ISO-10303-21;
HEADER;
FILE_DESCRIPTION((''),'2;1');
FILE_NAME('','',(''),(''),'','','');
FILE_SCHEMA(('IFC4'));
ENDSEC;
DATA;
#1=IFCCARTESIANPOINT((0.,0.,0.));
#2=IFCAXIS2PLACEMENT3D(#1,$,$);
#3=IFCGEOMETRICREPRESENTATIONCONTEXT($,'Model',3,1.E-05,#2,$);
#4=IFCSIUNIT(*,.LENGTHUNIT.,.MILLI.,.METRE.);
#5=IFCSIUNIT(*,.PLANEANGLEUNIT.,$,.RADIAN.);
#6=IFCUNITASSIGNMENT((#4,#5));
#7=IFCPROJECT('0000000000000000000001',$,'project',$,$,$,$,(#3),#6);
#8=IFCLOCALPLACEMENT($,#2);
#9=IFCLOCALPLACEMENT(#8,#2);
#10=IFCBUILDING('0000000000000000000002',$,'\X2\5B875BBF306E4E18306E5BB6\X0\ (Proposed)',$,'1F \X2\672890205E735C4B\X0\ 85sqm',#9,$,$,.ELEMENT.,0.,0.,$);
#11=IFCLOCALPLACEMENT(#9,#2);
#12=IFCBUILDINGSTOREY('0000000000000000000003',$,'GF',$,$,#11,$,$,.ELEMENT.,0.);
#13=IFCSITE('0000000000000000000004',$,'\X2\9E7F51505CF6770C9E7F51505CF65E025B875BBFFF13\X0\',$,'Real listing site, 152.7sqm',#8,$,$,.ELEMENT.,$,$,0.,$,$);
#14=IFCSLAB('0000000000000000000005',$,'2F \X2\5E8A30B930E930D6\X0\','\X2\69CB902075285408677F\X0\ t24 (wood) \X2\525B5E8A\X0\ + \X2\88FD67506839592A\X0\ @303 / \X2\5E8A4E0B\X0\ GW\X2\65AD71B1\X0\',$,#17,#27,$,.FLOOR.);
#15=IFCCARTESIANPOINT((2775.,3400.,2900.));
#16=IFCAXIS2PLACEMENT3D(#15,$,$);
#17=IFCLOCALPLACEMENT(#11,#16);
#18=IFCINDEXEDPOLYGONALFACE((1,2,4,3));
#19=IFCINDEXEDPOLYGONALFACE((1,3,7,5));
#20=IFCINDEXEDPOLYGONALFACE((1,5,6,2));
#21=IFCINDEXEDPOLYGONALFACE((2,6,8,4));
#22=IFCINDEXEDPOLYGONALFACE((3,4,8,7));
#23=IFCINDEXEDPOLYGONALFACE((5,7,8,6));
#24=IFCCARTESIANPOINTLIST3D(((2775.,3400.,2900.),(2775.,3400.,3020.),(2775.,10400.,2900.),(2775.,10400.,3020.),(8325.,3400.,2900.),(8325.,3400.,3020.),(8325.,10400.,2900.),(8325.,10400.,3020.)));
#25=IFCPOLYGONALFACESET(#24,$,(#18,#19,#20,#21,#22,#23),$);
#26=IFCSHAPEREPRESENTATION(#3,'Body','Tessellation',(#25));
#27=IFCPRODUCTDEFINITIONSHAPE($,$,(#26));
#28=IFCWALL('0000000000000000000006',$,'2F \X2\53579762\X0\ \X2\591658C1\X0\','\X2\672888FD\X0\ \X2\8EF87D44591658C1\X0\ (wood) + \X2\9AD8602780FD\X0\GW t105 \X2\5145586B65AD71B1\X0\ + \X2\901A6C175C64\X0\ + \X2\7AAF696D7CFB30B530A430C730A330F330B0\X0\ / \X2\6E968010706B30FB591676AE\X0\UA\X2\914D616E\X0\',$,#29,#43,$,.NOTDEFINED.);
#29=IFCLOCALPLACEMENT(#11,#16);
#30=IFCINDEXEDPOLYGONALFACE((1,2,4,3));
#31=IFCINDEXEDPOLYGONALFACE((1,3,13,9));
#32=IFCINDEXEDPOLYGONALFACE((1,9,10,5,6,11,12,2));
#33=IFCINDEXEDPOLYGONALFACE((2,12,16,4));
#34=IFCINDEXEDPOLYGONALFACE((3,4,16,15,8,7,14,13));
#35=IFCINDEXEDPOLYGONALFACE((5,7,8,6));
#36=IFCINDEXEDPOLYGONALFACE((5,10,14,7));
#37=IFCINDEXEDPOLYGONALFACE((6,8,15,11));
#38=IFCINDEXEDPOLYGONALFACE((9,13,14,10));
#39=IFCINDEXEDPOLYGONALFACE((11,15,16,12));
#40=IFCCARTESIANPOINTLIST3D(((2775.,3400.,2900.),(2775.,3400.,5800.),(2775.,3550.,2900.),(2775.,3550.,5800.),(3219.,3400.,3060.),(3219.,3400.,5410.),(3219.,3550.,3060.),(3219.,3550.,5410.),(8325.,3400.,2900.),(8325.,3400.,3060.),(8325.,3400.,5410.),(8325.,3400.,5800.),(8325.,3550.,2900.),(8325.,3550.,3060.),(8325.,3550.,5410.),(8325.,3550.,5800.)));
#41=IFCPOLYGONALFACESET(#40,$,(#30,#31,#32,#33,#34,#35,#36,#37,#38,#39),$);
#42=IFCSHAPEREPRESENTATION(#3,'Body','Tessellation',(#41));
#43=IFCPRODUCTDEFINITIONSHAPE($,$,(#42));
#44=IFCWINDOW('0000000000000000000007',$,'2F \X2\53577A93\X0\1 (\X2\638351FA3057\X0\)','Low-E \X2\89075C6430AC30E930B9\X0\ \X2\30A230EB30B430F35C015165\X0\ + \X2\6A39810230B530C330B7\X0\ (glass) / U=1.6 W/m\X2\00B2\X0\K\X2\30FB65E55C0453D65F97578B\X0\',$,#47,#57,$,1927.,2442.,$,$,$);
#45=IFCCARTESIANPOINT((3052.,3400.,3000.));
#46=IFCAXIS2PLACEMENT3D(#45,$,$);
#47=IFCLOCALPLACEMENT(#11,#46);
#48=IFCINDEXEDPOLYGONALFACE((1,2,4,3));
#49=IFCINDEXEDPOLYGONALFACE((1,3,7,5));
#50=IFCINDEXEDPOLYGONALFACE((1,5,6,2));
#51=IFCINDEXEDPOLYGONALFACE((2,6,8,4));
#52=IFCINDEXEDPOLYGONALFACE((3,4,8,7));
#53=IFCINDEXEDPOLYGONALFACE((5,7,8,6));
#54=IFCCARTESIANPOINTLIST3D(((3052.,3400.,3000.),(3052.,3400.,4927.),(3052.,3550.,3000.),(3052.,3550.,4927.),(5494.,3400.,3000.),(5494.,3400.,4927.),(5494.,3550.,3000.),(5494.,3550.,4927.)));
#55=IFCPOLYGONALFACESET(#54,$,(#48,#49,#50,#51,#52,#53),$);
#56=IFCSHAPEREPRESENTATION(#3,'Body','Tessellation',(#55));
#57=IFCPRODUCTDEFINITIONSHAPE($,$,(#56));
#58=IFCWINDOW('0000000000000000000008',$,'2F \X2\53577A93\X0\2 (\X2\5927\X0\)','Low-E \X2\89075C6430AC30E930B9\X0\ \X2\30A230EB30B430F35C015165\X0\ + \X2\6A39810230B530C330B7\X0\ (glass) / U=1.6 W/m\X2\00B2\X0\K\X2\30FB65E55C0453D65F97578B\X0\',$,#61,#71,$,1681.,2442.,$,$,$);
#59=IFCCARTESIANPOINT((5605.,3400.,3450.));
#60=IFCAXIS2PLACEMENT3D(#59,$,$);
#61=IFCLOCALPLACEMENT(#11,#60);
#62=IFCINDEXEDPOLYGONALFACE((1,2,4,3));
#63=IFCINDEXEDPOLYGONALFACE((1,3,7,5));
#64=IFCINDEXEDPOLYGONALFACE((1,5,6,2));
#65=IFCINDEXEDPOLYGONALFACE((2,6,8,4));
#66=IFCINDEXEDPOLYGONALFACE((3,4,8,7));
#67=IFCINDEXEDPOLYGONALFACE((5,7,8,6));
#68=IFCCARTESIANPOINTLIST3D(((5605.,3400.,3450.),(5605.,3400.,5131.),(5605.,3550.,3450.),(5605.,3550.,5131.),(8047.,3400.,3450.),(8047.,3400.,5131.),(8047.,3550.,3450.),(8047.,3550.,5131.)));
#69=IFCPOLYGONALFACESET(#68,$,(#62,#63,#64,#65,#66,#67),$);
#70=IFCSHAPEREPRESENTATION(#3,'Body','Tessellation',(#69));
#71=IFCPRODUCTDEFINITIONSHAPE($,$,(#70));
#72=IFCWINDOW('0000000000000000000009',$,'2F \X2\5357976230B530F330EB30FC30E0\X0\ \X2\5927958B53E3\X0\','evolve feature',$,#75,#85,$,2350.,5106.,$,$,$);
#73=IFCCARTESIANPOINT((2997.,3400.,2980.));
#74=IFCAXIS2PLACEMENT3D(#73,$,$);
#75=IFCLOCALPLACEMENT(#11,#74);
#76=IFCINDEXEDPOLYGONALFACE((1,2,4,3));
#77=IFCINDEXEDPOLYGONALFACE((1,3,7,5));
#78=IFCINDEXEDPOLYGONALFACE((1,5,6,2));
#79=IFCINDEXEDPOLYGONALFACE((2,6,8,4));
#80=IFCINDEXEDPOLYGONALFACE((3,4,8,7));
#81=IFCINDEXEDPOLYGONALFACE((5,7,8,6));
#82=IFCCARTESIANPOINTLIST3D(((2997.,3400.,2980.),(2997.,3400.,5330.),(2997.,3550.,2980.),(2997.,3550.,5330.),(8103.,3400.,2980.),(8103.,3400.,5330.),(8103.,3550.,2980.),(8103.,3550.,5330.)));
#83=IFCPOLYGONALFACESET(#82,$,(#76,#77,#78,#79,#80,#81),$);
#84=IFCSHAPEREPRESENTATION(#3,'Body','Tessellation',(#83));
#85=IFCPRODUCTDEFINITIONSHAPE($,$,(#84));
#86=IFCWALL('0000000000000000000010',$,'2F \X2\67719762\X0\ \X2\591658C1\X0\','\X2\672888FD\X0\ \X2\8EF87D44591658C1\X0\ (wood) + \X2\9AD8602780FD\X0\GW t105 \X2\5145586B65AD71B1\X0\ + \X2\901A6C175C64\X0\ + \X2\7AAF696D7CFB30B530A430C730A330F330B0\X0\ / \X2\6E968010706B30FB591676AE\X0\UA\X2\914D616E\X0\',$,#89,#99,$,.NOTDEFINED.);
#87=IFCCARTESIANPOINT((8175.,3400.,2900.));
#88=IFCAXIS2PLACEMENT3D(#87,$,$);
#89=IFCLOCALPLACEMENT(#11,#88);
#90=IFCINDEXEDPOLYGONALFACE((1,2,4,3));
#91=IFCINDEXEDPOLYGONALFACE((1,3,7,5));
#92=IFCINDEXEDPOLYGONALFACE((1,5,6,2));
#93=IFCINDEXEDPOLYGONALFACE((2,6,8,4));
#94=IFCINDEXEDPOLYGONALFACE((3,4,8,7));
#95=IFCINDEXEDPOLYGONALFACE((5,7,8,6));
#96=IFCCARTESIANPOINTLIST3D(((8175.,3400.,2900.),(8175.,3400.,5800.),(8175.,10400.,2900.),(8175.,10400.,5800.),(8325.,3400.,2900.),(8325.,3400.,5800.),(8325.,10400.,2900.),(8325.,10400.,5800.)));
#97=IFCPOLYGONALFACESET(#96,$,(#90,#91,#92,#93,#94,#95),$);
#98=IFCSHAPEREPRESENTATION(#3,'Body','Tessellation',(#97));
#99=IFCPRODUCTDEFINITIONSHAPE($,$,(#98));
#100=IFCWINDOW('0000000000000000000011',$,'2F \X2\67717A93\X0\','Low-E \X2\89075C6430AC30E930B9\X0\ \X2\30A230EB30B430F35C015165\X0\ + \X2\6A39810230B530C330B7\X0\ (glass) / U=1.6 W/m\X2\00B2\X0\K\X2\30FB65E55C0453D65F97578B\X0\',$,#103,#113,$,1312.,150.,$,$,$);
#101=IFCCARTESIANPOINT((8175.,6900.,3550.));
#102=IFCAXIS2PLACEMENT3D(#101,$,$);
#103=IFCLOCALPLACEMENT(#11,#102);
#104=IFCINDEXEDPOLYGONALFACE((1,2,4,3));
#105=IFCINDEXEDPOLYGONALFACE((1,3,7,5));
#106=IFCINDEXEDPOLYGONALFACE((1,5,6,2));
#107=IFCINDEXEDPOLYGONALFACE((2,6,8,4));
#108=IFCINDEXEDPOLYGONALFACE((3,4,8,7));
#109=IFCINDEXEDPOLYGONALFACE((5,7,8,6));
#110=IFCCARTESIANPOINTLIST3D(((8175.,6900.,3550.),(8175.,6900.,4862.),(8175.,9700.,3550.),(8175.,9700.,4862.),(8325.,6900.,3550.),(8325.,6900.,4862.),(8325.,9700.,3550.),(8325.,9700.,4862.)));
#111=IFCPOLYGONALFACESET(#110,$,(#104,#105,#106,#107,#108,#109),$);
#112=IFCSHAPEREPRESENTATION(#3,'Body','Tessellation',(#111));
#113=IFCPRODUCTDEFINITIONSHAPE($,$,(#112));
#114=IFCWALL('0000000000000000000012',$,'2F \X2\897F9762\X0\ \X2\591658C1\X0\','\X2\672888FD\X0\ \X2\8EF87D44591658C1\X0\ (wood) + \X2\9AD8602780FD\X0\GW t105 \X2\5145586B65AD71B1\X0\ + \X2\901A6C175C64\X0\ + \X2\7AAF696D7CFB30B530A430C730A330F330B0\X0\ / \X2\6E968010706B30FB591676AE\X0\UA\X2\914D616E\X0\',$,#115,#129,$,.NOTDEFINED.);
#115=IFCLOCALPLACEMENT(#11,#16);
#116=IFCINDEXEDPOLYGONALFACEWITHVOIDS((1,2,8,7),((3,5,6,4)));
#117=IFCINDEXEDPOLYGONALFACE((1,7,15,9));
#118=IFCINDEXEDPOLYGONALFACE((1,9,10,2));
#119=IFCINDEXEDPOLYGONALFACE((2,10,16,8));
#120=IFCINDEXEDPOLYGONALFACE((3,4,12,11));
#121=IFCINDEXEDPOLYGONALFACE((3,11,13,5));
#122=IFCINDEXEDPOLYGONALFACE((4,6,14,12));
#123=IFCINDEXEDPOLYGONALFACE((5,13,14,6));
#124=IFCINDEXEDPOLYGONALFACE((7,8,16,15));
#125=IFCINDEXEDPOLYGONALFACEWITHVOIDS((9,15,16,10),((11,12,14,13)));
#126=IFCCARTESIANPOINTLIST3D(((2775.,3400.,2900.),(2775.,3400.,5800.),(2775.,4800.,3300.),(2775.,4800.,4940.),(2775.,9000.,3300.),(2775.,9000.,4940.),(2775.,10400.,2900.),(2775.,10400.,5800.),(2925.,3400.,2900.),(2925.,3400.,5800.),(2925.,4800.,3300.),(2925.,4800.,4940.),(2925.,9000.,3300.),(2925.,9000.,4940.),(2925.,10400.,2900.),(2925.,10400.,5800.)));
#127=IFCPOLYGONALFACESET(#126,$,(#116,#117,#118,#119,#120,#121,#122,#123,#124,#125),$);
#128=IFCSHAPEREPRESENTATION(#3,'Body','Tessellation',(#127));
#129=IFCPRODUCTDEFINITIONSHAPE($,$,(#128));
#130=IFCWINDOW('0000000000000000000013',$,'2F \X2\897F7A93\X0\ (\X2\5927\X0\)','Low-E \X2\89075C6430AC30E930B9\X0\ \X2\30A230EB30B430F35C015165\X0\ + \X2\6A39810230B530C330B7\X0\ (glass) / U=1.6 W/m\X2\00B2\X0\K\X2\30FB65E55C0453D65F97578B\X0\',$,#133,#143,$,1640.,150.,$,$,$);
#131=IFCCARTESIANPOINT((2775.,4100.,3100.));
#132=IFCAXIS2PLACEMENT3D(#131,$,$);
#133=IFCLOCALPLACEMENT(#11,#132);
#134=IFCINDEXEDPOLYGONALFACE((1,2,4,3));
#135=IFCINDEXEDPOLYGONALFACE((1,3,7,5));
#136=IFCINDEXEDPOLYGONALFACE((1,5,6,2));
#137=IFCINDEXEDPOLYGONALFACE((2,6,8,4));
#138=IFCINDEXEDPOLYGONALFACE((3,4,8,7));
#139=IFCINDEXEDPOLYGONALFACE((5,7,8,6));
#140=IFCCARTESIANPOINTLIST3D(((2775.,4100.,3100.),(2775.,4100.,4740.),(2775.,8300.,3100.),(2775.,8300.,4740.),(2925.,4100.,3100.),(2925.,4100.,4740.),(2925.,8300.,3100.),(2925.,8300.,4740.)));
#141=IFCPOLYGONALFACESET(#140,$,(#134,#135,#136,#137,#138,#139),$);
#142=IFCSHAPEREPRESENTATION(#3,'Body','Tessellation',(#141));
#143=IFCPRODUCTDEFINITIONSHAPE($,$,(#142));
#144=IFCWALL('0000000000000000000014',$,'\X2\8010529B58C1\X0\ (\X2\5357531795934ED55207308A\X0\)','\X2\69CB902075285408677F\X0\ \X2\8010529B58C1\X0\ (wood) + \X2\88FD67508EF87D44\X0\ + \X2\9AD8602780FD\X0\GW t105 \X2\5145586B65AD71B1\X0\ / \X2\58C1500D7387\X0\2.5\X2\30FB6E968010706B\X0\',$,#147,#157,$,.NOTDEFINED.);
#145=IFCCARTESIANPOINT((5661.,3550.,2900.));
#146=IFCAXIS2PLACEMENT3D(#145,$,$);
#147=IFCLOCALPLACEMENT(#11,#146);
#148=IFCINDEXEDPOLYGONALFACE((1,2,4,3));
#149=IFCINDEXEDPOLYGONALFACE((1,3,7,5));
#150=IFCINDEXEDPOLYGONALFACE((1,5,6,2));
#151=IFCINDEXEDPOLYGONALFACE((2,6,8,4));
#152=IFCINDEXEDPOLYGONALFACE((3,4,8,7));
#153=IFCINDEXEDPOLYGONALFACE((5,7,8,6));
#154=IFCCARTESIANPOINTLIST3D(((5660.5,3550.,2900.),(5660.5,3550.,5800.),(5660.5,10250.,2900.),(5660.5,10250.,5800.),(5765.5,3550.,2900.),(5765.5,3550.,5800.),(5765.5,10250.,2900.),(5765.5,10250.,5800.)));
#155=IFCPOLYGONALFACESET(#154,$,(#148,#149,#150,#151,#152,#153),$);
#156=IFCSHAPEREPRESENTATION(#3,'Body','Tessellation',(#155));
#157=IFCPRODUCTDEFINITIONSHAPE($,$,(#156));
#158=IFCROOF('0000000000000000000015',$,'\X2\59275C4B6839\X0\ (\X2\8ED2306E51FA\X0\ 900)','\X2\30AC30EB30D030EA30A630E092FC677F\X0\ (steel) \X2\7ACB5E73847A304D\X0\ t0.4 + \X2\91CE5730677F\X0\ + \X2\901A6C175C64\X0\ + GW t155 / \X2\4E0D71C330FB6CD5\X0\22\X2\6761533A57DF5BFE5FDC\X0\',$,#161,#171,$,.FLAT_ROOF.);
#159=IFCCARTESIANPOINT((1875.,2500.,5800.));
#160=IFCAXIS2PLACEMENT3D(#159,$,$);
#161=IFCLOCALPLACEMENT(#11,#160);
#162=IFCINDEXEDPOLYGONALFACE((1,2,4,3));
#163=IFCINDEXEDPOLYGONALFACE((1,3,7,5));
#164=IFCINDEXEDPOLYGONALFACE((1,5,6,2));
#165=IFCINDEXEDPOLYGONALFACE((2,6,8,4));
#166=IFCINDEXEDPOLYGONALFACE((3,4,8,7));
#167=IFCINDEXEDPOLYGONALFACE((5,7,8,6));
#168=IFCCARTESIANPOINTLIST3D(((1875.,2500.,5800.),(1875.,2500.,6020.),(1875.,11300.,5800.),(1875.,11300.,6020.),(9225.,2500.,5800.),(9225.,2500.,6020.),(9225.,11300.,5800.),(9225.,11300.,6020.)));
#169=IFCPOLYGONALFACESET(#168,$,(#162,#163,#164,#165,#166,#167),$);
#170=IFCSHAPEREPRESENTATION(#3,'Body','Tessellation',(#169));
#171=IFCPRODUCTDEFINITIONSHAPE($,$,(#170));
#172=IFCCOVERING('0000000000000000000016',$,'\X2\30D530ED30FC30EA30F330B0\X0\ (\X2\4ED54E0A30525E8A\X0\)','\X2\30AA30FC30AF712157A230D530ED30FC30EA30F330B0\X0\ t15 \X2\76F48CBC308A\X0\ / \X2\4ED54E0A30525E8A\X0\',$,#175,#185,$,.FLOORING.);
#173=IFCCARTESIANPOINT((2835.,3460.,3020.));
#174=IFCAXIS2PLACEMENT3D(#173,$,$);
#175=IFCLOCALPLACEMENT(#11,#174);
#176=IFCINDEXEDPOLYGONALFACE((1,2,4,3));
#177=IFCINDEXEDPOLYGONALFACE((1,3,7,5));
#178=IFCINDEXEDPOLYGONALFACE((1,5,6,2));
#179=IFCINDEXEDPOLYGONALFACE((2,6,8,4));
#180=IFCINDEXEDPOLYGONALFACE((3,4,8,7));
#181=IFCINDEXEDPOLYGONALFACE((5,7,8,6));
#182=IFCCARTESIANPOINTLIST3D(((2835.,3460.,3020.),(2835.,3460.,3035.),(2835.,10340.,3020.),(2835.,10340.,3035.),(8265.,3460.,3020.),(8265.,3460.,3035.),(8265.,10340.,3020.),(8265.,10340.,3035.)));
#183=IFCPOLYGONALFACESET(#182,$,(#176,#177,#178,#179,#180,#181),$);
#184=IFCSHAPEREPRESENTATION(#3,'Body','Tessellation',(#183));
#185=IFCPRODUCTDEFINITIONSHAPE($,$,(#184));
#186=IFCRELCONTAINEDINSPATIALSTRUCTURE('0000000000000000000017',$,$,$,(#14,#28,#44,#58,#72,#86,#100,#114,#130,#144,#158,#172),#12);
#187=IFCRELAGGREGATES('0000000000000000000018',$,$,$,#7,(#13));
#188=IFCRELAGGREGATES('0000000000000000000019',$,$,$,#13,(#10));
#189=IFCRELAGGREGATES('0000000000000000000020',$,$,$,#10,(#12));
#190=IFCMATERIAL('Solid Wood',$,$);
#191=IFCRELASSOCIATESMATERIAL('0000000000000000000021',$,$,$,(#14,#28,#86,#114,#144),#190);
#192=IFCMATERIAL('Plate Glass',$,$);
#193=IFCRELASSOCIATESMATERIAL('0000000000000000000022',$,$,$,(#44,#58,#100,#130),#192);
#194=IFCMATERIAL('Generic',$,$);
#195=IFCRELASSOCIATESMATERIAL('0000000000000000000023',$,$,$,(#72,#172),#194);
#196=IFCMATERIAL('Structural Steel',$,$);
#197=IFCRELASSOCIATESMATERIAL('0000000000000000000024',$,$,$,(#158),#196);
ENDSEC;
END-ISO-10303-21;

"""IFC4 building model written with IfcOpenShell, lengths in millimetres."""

from ifc_helpers import new_model, si_unit, frame, frame_2d, origin, place, context, project, spatial, rectangle, extrude, material, element, fill, save


model = new_model("IFC4")

# Units and contexts
model_context = context("Model", 3, precision=1e-05, world=origin())
ifc_project = project(units=[si_unit("LENGTHUNIT", "METRE", prefix="MILLI"), si_unit("PLANEANGLEUNIT", "RADIAN")], contexts=[model_context])

# Site, building, storey
site_placement = place(None, origin())
site = spatial("IfcSite", under=ifc_project, at=site_placement, Name="鹿児島県鹿児島市宇宿３", ObjectType="Real listing site, 152.7sqm", CompositionType="ELEMENT", RefElevation=0.0)
building_placement = place(site_placement, origin())
building = spatial("IfcBuilding", under=site, at=building_placement, Name="宇宿の丘の家 (Proposed)", ObjectType="1F 木造平屋 85sqm", CompositionType="ELEMENT", ElevationOfRefHeight=0.0, ElevationOfTerrain=0.0)
storey_placement = place(building_placement, origin())
storey = spatial("IfcBuildingStorey", under=building, at=storey_placement, Name="GF", CompositionType="ELEMENT", Elevation=0.0)

# Slab
ifc_material_1 = material(Name="Solid Wood")
slab_placement = place(storey_placement, frame((2775.0, 3400.0, 2900.0)))
element("IfcSlab", 1, at=slab_placement, inside=storey, material=ifc_material_1, Name="2F 床スラブ", Description="構造用合板 t24 (wood) 剛床 + 製材根太 @303 / 床下 GW断熱", PredefinedType="FLOOR", context=model_context, shape_type="SweptSolid", body=[
    extrude(rectangle(XDim=5550.0, YDim=7000.0, at=frame_2d((2775.0, 3500.0))), frame((2775.0, 3400.0, 2900.0)), (0.0, 0.0, 1.0), 120.0),
])

# Wall, openings, windows
wall_1_placement = place(storey_placement, frame((2775.0, 3400.0, 2900.0)))
wall_1 = element("IfcWall", 2, at=wall_1_placement, inside=storey, material=ifc_material_1, Name="2F 南面 外壁", Description="木製 軸組外壁 (wood) + 高性能GW t105 充填断熱 + 通気層 + 窯業系サイディング / 準耐火・外皮UA配慮", PredefinedType="NOTDEFINED", context=model_context, shape_type="SweptSolid", body=[
    extrude(rectangle(XDim=5550.0, YDim=150.0, at=frame_2d((2775.0, 75.0))), frame((2775.0, 3400.0, 2900.0)), (0.0, 0.0, 1.0), 2900.0),
])
opening_1_placement = place(storey_placement, frame((3052.0, 3400.0, 3000.0)))
opening_1 = element("IfcOpeningElement", 3, at=opening_1_placement, cuts=wall_1, PredefinedType="NOTDEFINED", context=model_context, shape_type="SweptSolid", body=[
    extrude(rectangle(XDim=2442.0, YDim=150.0, at=frame_2d((1221.0, 75.0))), frame((3052.0, 3400.0, 3000.0)), (0.0, 0.0, 1.0), 1927.0),
])
opening_2_placement = place(storey_placement, frame((5605.0, 3400.0, 3450.0)))
opening_2 = element("IfcOpeningElement", 4, at=opening_2_placement, cuts=wall_1, PredefinedType="NOTDEFINED", context=model_context, shape_type="SweptSolid", body=[
    extrude(rectangle(XDim=2442.0, YDim=150.0, at=frame_2d((1221.0, 75.0))), frame((5605.0, 3400.0, 3450.0)), (0.0, 0.0, 1.0), 1681.0),
])
opening_3_placement = place(storey_placement, frame((2997.0, 3400.0, 2980.0)))
opening_3 = element("IfcOpeningElement", 5, at=opening_3_placement, cuts=wall_1, PredefinedType="NOTDEFINED", context=model_context, shape_type="SweptSolid", body=[
    extrude(rectangle(XDim=5106.0, YDim=150.0, at=frame_2d((2553.0, 75.0))), frame((2997.0, 3400.0, 2980.0)), (0.0, 0.0, 1.0), 2350.0),
])
ifc_material_2 = material(Name="Plate Glass")
window_1_placement = place(storey_placement, frame((3052.0, 3400.0, 3000.0)))
window_1 = element("IfcWindow", 6, at=window_1_placement, inside=storey, material=ifc_material_2, Name="2F 南窓1 (掃出し)", Description="Low-E 複層ガラス アルゴン封入 + 樹脂サッシ (glass) / U=1.6 W/m²K・日射取得型", OverallHeight=1927.0, OverallWidth=2442.0, context=model_context, shape_type="SweptSolid", body=[
    extrude(rectangle(XDim=2442.0, YDim=150.0, at=frame_2d((1221.0, 75.0))), frame((3052.0, 3400.0, 3000.0)), (0.0, 0.0, 1.0), 1927.0),
])
fill(opening_1, window_1)
window_2_placement = place(storey_placement, frame((5605.0, 3400.0, 3450.0)))
window_2 = element("IfcWindow", 7, at=window_2_placement, inside=storey, material=ifc_material_2, Name="2F 南窓2 (大)", Description="Low-E 複層ガラス アルゴン封入 + 樹脂サッシ (glass) / U=1.6 W/m²K・日射取得型", OverallHeight=1681.0, OverallWidth=2442.0, context=model_context, shape_type="SweptSolid", body=[
    extrude(rectangle(XDim=2442.0, YDim=150.0, at=frame_2d((1221.0, 75.0))), frame((5605.0, 3400.0, 3450.0)), (0.0, 0.0, 1.0), 1681.0),
])
fill(opening_2, window_2)
ifc_material_3 = material(Name="Generic")
window_3_placement = place(storey_placement, frame((2997.0, 3400.0, 2980.0)))
window_3 = element("IfcWindow", 8, at=window_3_placement, inside=storey, material=ifc_material_3, Name="2F 南面サンルーム 大開口", Description="evolve feature", OverallHeight=2350.0, OverallWidth=5106.0, context=model_context, shape_type="SweptSolid", body=[
    extrude(rectangle(XDim=5106.0, YDim=150.0, at=frame_2d((2553.0, 75.0))), frame((2997.0, 3400.0, 2980.0)), (0.0, 0.0, 1.0), 2350.0),
])
fill(opening_3, window_3)

# Walls, openings, windows
wall_2_placement = place(storey_placement, frame((8175.0, 3400.0, 2900.0)))
wall_2 = element("IfcWall", 9, at=wall_2_placement, inside=storey, material=ifc_material_1, Name="2F 東面 外壁", Description="木製 軸組外壁 (wood) + 高性能GW t105 充填断熱 + 通気層 + 窯業系サイディング / 準耐火・外皮UA配慮", PredefinedType="NOTDEFINED", context=model_context, shape_type="SweptSolid", body=[
    extrude(rectangle(XDim=150.0, YDim=7000.0, at=frame_2d((75.0, 3500.0))), frame((8175.0, 3400.0, 2900.0)), (0.0, 0.0, 1.0), 2900.0),
])
opening_4_placement = place(storey_placement, frame((8175.0, 6900.0, 3550.0)))
opening_4 = element("IfcOpeningElement", 10, at=opening_4_placement, cuts=wall_2, PredefinedType="NOTDEFINED", context=model_context, shape_type="SweptSolid", body=[
    extrude(rectangle(XDim=150.0, YDim=2800.0, at=frame_2d((75.0, 1400.0))), frame((8175.0, 6900.0, 3550.0)), (0.0, 0.0, 1.0), 1312.0),
])
window_4_placement = place(storey_placement, frame((8175.0, 6900.0, 3550.0)))
window_4 = element("IfcWindow", 11, at=window_4_placement, inside=storey, material=ifc_material_2, Name="2F 東窓", Description="Low-E 複層ガラス アルゴン封入 + 樹脂サッシ (glass) / U=1.6 W/m²K・日射取得型", OverallHeight=1312.0, OverallWidth=150.0, context=model_context, shape_type="SweptSolid", body=[
    extrude(rectangle(XDim=150.0, YDim=2800.0, at=frame_2d((75.0, 1400.0))), frame((8175.0, 6900.0, 3550.0)), (0.0, 0.0, 1.0), 1312.0),
])
fill(opening_4, window_4)
wall_3_placement = place(storey_placement, frame((2775.0, 3400.0, 2900.0)))
wall_3 = element("IfcWall", 12, at=wall_3_placement, inside=storey, material=ifc_material_1, Name="2F 西面 外壁", Description="木製 軸組外壁 (wood) + 高性能GW t105 充填断熱 + 通気層 + 窯業系サイディング / 準耐火・外皮UA配慮", PredefinedType="NOTDEFINED", context=model_context, shape_type="SweptSolid", body=[
    extrude(rectangle(XDim=150.0, YDim=7000.0, at=frame_2d((75.0, 3500.0))), frame((2775.0, 3400.0, 2900.0)), (0.0, 0.0, 1.0), 2900.0),
])
opening_5_placement = place(storey_placement, frame((2775.0, 4100.0, 3100.0)))
opening_5 = element("IfcOpeningElement", 13, at=opening_5_placement, cuts=wall_3, PredefinedType="NOTDEFINED", context=model_context, shape_type="SweptSolid", body=[
    extrude(rectangle(XDim=150.0, YDim=4200.0, at=frame_2d((75.0, 2100.0))), frame((2775.0, 4100.0, 3100.0)), (0.0, 0.0, 1.0), 1640.0),
])
window_5_placement = place(storey_placement, frame((2775.0, 4100.0, 3100.0)))
window_5 = element("IfcWindow", 14, at=window_5_placement, inside=storey, material=ifc_material_2, Name="2F 西窓 (大)", Description="Low-E 複層ガラス アルゴン封入 + 樹脂サッシ (glass) / U=1.6 W/m²K・日射取得型", OverallHeight=1640.0, OverallWidth=150.0, context=model_context, shape_type="SweptSolid", body=[
    extrude(rectangle(XDim=150.0, YDim=4200.0, at=frame_2d((75.0, 2100.0))), frame((2775.0, 4100.0, 3100.0)), (0.0, 0.0, 1.0), 1640.0),
])
fill(opening_5, window_5)

# Wall
wall_4_placement = place(storey_placement, frame((5661.0, 3550.0, 2900.0)))
element("IfcWall", 15, at=wall_4_placement, inside=storey, material=ifc_material_1, Name="耐力壁 (南北間仕切り)", Description="構造用合板 耐力壁 (wood) + 製材軸組 + 高性能GW t105 充填断熱 / 壁倍率2.5・準耐火", PredefinedType="NOTDEFINED", context=model_context, shape_type="SweptSolid", body=[
    extrude(rectangle(XDim=105.0, YDim=6700.0, at=frame_2d((52.0, 3350.0))), frame((5661.0, 3550.0, 2900.0)), (0.0, 0.0, 1.0), 2900.0),
])

# Roof
ifc_material_4 = material(Name="Structural Steel")
roof_placement = place(storey_placement, frame((1875.0, 2500.0, 5800.0)))
element("IfcRoof", 16, at=roof_placement, inside=storey, material=ifc_material_4, Name="大屋根 (軒の出 900)", Description="ガルバリウム鋼板 (steel) 立平葺き t0.4 + 野地板 + 通気層 + GW t155 / 不燃・法22条区域対応", PredefinedType="FLAT_ROOF", context=model_context, shape_type="SweptSolid", body=[
    extrude(rectangle(XDim=7350.0, YDim=8800.0, at=frame_2d((3675.0, 4400.0))), frame((1875.0, 2500.0, 5800.0)), (0.0, 0.0, 1.0), 220.0),
])

# Covering
covering_placement = place(storey_placement, frame((2835.0, 3460.0, 3020.0)))
element("IfcCovering", 17, at=covering_placement, inside=storey, material=ifc_material_3, Name="フローリング (仕上げ床)", Description="オーク無垢フローリング t15 直貼り / 仕上げ床", PredefinedType="FLOORING", context=model_context, shape_type="SweptSolid", body=[
    extrude(rectangle(XDim=5430.0, YDim=6880.0, at=frame_2d((2715.0, 3440.0))), frame((2835.0, 3460.0, 3020.0)), (0.0, 0.0, 1.0), 15.0),
])

save(model, "model.ifc")
